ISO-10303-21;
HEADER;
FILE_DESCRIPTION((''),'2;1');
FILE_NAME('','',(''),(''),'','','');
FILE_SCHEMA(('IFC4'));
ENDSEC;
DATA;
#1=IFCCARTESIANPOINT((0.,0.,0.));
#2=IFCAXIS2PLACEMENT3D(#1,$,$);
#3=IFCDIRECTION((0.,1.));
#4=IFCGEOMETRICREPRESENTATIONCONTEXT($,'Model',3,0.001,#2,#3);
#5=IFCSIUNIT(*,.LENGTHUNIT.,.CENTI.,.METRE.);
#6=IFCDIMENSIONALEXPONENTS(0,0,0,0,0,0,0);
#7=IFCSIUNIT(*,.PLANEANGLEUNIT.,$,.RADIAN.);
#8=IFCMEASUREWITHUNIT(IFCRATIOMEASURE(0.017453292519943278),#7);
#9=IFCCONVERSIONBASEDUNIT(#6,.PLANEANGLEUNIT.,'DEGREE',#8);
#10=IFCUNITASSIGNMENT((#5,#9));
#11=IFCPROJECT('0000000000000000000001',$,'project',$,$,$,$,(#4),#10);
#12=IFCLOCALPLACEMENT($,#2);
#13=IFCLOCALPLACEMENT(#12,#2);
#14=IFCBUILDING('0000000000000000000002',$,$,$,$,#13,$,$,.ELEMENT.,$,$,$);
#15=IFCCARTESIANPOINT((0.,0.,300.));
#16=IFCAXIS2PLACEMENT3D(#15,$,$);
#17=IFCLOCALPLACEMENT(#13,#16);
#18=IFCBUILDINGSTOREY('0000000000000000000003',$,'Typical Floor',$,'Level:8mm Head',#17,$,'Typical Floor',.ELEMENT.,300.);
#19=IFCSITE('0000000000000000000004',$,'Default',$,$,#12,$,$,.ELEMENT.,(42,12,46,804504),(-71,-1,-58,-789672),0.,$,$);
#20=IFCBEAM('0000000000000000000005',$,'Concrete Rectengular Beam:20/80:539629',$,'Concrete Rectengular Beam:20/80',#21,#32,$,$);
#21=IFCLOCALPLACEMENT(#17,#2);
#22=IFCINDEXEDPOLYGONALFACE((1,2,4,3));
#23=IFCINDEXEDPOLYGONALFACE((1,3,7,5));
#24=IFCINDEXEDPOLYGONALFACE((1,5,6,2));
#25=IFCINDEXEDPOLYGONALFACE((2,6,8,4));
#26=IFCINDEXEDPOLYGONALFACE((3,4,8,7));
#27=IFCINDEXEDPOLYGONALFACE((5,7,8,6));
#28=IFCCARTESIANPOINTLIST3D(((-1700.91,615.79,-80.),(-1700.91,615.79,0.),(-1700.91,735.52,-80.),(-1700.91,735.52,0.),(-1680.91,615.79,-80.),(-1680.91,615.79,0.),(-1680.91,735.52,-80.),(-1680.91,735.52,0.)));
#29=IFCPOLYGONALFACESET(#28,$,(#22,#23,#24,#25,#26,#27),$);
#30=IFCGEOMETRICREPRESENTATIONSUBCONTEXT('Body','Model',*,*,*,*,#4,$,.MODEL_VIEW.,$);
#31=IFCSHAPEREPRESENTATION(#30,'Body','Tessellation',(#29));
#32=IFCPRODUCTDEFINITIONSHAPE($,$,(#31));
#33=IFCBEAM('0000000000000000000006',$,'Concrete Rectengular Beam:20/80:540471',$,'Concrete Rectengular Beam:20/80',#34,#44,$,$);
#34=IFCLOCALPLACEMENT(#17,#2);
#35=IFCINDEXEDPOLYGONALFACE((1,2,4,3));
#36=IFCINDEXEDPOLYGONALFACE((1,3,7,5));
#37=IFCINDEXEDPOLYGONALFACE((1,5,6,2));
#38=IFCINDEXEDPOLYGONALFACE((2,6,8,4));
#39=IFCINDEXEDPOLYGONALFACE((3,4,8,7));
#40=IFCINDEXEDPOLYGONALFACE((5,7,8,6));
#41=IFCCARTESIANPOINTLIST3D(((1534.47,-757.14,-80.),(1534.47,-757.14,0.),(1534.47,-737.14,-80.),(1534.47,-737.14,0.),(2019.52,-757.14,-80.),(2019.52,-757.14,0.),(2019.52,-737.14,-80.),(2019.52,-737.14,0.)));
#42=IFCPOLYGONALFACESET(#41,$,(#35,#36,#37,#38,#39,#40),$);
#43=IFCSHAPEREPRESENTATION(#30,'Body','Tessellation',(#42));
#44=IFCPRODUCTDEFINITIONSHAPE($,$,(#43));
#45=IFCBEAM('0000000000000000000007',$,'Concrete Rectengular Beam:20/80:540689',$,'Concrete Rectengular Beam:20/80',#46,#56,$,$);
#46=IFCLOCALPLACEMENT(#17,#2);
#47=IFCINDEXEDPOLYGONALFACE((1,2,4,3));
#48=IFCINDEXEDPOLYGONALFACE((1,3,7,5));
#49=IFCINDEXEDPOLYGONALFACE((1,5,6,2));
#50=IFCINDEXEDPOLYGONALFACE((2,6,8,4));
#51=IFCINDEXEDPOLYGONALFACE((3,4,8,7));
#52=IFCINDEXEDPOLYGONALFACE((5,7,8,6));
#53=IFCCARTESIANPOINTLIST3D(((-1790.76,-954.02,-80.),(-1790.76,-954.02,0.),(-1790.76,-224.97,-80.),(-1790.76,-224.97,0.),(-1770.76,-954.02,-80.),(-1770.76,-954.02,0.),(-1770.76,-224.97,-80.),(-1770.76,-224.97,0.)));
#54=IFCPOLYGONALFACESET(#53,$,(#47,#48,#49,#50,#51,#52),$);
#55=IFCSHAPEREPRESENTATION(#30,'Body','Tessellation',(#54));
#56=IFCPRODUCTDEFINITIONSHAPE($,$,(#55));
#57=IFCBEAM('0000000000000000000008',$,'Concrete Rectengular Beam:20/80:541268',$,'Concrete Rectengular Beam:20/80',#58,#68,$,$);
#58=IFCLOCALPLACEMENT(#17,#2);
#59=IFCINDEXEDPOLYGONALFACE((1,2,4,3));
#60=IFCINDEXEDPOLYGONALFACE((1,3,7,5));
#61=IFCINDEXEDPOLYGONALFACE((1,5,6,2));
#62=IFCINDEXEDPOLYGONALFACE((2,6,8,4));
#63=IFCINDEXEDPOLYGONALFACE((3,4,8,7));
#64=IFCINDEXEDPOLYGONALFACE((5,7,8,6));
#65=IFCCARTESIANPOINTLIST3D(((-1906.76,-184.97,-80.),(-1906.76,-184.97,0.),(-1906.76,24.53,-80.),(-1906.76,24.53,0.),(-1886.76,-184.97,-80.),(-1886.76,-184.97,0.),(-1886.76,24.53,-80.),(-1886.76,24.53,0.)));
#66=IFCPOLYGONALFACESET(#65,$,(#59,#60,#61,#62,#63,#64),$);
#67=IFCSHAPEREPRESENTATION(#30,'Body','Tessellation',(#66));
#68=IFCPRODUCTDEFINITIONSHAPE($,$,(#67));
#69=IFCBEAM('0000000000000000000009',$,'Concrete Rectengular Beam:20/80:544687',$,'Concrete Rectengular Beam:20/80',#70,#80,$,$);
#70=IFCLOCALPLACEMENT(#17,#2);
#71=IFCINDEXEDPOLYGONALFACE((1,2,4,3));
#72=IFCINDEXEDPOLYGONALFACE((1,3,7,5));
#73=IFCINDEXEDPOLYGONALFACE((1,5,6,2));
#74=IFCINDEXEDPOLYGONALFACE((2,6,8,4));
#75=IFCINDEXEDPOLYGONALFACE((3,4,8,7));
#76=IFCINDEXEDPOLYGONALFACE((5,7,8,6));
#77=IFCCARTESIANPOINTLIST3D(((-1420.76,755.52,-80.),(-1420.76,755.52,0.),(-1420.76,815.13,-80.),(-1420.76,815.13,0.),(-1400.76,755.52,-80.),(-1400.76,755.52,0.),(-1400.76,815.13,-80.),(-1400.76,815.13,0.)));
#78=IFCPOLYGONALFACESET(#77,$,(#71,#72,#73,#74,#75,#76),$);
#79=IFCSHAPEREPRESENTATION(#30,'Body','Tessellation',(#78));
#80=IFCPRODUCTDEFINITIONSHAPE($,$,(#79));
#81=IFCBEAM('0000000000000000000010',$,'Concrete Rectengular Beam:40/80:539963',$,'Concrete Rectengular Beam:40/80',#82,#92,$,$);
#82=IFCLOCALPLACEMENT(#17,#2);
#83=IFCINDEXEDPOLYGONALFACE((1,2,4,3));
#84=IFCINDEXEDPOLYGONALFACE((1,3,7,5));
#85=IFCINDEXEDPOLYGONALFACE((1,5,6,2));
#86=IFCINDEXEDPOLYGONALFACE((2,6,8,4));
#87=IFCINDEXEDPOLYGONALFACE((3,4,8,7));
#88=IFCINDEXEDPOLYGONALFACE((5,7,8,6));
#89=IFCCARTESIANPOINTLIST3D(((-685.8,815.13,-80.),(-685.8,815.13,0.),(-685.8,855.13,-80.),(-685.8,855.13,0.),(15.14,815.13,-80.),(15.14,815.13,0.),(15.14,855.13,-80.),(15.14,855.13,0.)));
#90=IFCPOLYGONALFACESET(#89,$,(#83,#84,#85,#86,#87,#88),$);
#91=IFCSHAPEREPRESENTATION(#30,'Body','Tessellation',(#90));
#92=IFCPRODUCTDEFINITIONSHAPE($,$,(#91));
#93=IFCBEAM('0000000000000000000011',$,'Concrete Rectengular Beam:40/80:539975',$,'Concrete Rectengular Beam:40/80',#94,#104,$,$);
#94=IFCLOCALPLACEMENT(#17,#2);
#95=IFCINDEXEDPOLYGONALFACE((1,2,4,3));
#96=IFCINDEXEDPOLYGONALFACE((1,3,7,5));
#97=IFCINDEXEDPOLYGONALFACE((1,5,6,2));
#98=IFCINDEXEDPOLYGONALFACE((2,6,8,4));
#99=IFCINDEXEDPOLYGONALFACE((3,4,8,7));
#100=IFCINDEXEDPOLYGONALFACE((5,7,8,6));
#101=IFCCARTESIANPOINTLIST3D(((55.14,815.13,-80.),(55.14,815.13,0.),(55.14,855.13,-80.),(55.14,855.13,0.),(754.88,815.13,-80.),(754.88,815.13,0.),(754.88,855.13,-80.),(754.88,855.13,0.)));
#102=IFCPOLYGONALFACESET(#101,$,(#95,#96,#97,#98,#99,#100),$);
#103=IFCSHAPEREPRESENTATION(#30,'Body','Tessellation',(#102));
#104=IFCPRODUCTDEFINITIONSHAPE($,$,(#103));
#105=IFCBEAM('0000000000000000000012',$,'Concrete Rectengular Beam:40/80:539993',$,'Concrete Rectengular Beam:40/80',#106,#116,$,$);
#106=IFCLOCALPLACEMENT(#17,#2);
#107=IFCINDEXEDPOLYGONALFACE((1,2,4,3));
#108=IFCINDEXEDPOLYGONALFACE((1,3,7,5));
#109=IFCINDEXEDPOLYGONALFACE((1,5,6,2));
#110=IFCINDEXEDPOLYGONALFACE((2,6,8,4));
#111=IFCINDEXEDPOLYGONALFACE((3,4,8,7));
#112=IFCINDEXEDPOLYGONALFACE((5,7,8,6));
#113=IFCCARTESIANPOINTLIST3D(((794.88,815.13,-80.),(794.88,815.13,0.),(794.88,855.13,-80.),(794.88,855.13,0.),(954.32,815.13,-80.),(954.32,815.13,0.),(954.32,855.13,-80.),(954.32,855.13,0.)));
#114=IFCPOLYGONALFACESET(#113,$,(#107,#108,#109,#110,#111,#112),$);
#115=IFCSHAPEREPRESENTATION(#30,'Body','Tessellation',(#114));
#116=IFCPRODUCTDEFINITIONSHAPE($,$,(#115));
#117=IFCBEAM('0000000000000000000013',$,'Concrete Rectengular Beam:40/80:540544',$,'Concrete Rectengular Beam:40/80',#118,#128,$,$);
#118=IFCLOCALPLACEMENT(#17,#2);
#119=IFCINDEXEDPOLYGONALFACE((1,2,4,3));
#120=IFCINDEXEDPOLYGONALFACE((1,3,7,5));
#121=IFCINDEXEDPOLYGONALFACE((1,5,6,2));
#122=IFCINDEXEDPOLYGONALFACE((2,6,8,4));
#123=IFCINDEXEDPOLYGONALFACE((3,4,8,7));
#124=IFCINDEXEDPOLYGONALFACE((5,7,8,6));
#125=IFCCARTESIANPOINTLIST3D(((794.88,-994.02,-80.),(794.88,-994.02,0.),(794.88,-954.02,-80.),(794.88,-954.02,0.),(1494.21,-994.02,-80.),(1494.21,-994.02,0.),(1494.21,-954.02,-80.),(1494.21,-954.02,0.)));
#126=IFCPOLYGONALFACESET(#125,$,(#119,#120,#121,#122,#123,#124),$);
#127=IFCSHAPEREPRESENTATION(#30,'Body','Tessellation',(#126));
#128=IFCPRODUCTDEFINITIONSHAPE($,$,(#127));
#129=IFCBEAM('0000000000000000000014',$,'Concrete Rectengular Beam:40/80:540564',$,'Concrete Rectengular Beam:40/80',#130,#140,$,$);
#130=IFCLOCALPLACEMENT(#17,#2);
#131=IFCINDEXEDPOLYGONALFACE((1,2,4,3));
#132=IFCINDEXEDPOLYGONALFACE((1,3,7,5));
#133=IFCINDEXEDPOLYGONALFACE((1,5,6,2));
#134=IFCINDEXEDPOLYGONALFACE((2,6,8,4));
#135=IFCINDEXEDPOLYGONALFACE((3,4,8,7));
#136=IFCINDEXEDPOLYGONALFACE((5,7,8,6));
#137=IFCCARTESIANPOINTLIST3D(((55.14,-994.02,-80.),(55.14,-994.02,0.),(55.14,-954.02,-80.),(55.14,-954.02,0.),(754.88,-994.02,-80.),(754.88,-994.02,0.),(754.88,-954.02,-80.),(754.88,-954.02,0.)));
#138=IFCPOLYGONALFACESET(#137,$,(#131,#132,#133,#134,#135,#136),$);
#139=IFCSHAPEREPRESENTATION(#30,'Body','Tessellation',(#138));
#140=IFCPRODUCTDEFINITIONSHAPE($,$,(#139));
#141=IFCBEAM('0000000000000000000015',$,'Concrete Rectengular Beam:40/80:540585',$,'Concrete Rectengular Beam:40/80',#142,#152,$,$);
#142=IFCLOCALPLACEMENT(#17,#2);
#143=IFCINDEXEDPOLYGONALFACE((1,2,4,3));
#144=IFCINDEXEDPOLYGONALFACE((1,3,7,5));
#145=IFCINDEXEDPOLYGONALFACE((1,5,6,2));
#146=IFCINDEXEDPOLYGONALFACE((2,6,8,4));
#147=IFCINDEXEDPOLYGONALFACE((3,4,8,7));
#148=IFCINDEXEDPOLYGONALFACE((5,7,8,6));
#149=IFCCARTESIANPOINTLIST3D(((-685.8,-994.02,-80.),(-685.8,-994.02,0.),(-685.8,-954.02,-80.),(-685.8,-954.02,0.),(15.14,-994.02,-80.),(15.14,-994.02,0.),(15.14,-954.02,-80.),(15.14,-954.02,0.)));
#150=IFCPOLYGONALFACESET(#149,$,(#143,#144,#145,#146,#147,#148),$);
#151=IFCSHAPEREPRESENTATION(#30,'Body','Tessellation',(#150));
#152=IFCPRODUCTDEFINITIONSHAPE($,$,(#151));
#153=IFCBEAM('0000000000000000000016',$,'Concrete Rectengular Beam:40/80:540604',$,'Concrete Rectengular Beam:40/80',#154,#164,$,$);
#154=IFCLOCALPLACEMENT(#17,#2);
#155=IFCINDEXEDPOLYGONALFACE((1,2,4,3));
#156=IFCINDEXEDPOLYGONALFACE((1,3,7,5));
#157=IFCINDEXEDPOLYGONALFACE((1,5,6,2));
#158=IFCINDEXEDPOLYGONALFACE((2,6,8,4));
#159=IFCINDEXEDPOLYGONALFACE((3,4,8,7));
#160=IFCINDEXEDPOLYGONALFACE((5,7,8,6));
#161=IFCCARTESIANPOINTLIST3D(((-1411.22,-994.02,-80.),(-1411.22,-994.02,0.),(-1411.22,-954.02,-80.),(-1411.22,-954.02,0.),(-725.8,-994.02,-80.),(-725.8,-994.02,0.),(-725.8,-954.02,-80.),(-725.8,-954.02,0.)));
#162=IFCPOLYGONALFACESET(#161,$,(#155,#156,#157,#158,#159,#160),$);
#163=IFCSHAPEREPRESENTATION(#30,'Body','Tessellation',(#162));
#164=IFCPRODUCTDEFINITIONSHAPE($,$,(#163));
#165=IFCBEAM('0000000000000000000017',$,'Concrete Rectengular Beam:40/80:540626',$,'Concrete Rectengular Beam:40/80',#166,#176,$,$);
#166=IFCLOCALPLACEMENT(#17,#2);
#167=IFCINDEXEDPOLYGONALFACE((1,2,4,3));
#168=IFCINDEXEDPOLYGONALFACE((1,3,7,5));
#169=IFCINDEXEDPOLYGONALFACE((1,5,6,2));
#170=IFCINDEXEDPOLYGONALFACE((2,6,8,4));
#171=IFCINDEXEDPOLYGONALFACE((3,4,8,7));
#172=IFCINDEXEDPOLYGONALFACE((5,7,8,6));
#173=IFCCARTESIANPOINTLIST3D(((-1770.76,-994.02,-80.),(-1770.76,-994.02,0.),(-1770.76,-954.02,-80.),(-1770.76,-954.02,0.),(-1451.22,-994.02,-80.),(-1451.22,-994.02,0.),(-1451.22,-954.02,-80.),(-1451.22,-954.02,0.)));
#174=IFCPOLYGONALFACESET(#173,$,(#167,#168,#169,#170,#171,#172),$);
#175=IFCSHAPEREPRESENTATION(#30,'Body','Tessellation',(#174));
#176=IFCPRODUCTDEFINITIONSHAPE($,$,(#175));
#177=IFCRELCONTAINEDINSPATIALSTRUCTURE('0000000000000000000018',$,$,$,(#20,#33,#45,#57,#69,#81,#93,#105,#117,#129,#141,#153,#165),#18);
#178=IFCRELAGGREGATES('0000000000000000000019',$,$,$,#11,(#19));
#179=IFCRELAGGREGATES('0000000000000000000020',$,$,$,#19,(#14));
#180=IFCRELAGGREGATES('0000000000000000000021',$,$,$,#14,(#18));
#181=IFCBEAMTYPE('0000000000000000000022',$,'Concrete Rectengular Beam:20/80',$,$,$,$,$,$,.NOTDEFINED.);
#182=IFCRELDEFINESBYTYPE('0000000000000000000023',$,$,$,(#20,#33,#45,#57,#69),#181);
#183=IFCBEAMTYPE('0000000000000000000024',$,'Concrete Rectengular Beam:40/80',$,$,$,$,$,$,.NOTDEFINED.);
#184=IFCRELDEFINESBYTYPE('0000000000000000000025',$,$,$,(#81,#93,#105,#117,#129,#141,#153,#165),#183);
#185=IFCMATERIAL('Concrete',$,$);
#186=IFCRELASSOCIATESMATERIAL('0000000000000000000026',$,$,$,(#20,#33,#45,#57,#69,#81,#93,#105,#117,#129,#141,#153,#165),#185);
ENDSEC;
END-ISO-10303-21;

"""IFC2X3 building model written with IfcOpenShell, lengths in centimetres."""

from ifc_helpers import new_model, entity, si_unit, converted_unit, direction, frame, frame_2d, origin, place, context, subcontext, project, spatial, rectangle, extrude, material, type_object, element, save


model = new_model("IFC2X3")

# Units and contexts
model_context = context("Model", 3, precision=0.001, world=origin(), true_north=direction((0.0, 1.0)))
body_context = subcontext(model_context, "Body", "Model", "MODEL_VIEW")
ifc_project = project(units=[si_unit("LENGTHUNIT", "METRE", prefix="CENTI"), converted_unit("PLANEANGLEUNIT", "DEGREE", entity("IfcRatioMeasure", 0.017453292519943278), si_unit("PLANEANGLEUNIT", "RADIAN"), dimensions=[0, 0, 0, 0, 0, 0, 0])], contexts=[model_context])

# Site, building, storey
site_placement = place(None, origin())
site = spatial("IfcSite", under=ifc_project, at=site_placement, Name="Default", CompositionType="ELEMENT", RefLatitude=(42, 12, 46, 804504), RefLongitude=(-71, -1, -58, -789672), RefElevation=0.0)
building_placement = place(site_placement, origin())
building = spatial("IfcBuilding", under=site, at=building_placement, CompositionType="ELEMENT")
storey_placement = place(building_placement, frame((0.0, 0.0, 300.0)))
storey = spatial("IfcBuildingStorey", under=building, at=storey_placement, Name="Typical Floor", ObjectType="Level:8mm Head", LongName="Typical Floor", CompositionType="ELEMENT", Elevation=300.0)

# Beams
ifc_material = material(Name="Concrete")
beam_type_1 = type_object("IfcBeamType", Name="Concrete Rectengular Beam:20/80", PredefinedType="NOTDEFINED")
beam_1_placement = place(storey_placement, frame((-1690.91, 745.52, 0.0), z_axis=(0.0, 0.0, 1.0), x_axis=(0.0, -1.0, 0.0)))
element("IfcBeam", 1, at=beam_1_placement, inside=storey, type_object=beam_type_1, material=ifc_material, Name="Concrete Rectengular Beam:20/80:539629", ObjectType="Concrete Rectengular Beam:20/80", context=body_context, shape_type="SweptSolid", body=[
    extrude(rectangle(XDim=80.0, YDim=20.0, at=frame_2d((0.0, 0.0), x_axis=(1.0, 0.0))), frame((10.0, 0.0, -40.0), z_axis=(1.0, 0.0, 0.0), x_axis=(0.0, 0.0, -1.0)), (0.0, 0.0, 1.0), 119.74),
])
beam_2_placement = place(storey_placement, frame((2029.52, -747.14, 0.0), z_axis=(0.0, 0.0, 1.0), x_axis=(-1.0, 0.0, 0.0)))
element("IfcBeam", 2, at=beam_2_placement, inside=storey, type_object=beam_type_1, material=ifc_material, Name="Concrete Rectengular Beam:20/80:540471", ObjectType="Concrete Rectengular Beam:20/80", context=body_context, shape_type="SweptSolid", body=[
    extrude(rectangle(XDim=80.0, YDim=20.0, at=frame_2d((0.0, 0.0), x_axis=(1.0, 0.0))), frame((10.0, 0.0, -40.0), z_axis=(1.0, 0.0, 0.0), x_axis=(0.0, 0.0, -1.0)), (0.0, 0.0, 1.0), 485.05),
])
beam_3_placement = place(storey_placement, frame((-1780.76, -204.97, 0.0), z_axis=(0.0, 0.0, 1.0), x_axis=(0.0, -1.0, 0.0)))
element("IfcBeam", 3, at=beam_3_placement, inside=storey, type_object=beam_type_1, material=ifc_material, Name="Concrete Rectengular Beam:20/80:540689", ObjectType="Concrete Rectengular Beam:20/80", context=body_context, shape_type="SweptSolid", body=[
    extrude(rectangle(XDim=80.0, YDim=20.0, at=frame_2d((0.0, 0.0), x_axis=(1.0, 0.0))), frame((20.0, 0.0, -40.0), z_axis=(1.0, 0.0, 0.0), x_axis=(0.0, 0.0, -1.0)), (0.0, 0.0, 1.0), 729.05),
])
beam_4_placement = place(storey_placement, frame((-1896.76, -204.97, 0.0), z_axis=(0.0, 0.0, 1.0), x_axis=(0.0, 1.0, 0.0)))
element("IfcBeam", 4, at=beam_4_placement, inside=storey, type_object=beam_type_1, material=ifc_material, Name="Concrete Rectengular Beam:20/80:541268", ObjectType="Concrete Rectengular Beam:20/80", context=body_context, shape_type="SweptSolid", body=[
    extrude(rectangle(XDim=80.0, YDim=20.0, at=frame_2d((0.0, 0.0), x_axis=(1.0, 0.0))), frame((20.0, 0.0, -40.0), z_axis=(1.0, 0.0, 0.0), x_axis=(0.0, 0.0, -1.0)), (0.0, 0.0, 1.0), 209.5),
])
beam_5_placement = place(storey_placement, frame((-1410.76, 835.13, 0.0), z_axis=(0.0, 0.0, 1.0), x_axis=(0.0, -1.0, 0.0)))
element("IfcBeam", 5, at=beam_5_placement, inside=storey, type_object=beam_type_1, material=ifc_material, Name="Concrete Rectengular Beam:20/80:544687", ObjectType="Concrete Rectengular Beam:20/80", context=body_context, shape_type="SweptSolid", body=[
    extrude(rectangle(XDim=80.0, YDim=20.0, at=frame_2d((0.0, 0.0), x_axis=(1.0, 0.0))), frame((20.0, 0.0, -40.0), z_axis=(1.0, 0.0, 0.0), x_axis=(0.0, 0.0, -1.0)), (0.0, 0.0, 1.0), 59.61),
])
beam_type_2 = type_object("IfcBeamType", Name="Concrete Rectengular Beam:40/80", PredefinedType="NOTDEFINED")
beam_6_placement = place(storey_placement, frame((-705.8, 835.13, 0.0)))
element("IfcBeam", 6, at=beam_6_placement, inside=storey, type_object=beam_type_2, material=ifc_material, Name="Concrete Rectengular Beam:40/80:539963", ObjectType="Concrete Rectengular Beam:40/80", context=body_context, shape_type="SweptSolid", body=[
    extrude(rectangle(XDim=80.0, YDim=40.0, at=frame_2d((0.0, 0.0), x_axis=(1.0, 0.0))), frame((20.0, 0.0, -40.0), z_axis=(1.0, 0.0, 0.0), x_axis=(0.0, 0.0, -1.0)), (0.0, 0.0, 1.0), 700.94),
])
beam_7_placement = place(storey_placement, frame((35.14, 835.13, 0.0)))
element("IfcBeam", 7, at=beam_7_placement, inside=storey, type_object=beam_type_2, material=ifc_material, Name="Concrete Rectengular Beam:40/80:539975", ObjectType="Concrete Rectengular Beam:40/80", context=body_context, shape_type="SweptSolid", body=[
    extrude(rectangle(XDim=80.0, YDim=40.0, at=frame_2d((0.0, 0.0), x_axis=(1.0, 0.0))), frame((20.0, 0.0, -40.0), z_axis=(1.0, 0.0, 0.0), x_axis=(0.0, 0.0, -1.0)), (0.0, 0.0, 1.0), 699.74),
])
beam_8_placement = place(storey_placement, frame((774.88, 835.13, 0.0)))
element("IfcBeam", 8, at=beam_8_placement, inside=storey, type_object=beam_type_2, material=ifc_material, Name="Concrete Rectengular Beam:40/80:539993", ObjectType="Concrete Rectengular Beam:40/80", context=body_context, shape_type="SweptSolid", body=[
    extrude(rectangle(XDim=80.0, YDim=40.0, at=frame_2d((0.0, 0.0), x_axis=(1.0, 0.0))), frame((20.0, 0.0, -40.0), z_axis=(1.0, 0.0, 0.0), x_axis=(0.0, 0.0, -1.0)), (0.0, 0.0, 1.0), 159.44),
])
beam_9_placement = place(storey_placement, frame((1514.21, -974.02, 0.0), z_axis=(0.0, 0.0, 1.0), x_axis=(-1.0, 0.0, 0.0)))
element("IfcBeam", 9, at=beam_9_placement, inside=storey, type_object=beam_type_2, material=ifc_material, Name="Concrete Rectengular Beam:40/80:540544", ObjectType="Concrete Rectengular Beam:40/80", context=body_context, shape_type="SweptSolid", body=[
    extrude(rectangle(XDim=80.0, YDim=40.0, at=frame_2d((0.0, 0.0), x_axis=(1.0, 0.0))), frame((20.0, 0.0, -40.0), z_axis=(1.0, 0.0, 0.0), x_axis=(0.0, 0.0, -1.0)), (0.0, 0.0, 1.0), 699.33),
])
beam_10_placement = place(storey_placement, frame((774.88, -974.02, 0.0), z_axis=(0.0, 0.0, 1.0), x_axis=(-1.0, 0.0, 0.0)))
element("IfcBeam", 10, at=beam_10_placement, inside=storey, type_object=beam_type_2, material=ifc_material, Name="Concrete Rectengular Beam:40/80:540564", ObjectType="Concrete Rectengular Beam:40/80", context=body_context, shape_type="SweptSolid", body=[
    extrude(rectangle(XDim=80.0, YDim=40.0, at=frame_2d((0.0, 0.0), x_axis=(1.0, 0.0))), frame((20.0, 0.0, -40.0), z_axis=(1.0, 0.0, 0.0), x_axis=(0.0, 0.0, -1.0)), (0.0, 0.0, 1.0), 699.74),
])
beam_11_placement = place(storey_placement, frame((35.14, -974.02, 0.0), z_axis=(0.0, 0.0, 1.0), x_axis=(-1.0, 0.0, 0.0)))
element("IfcBeam", 11, at=beam_11_placement, inside=storey, type_object=beam_type_2, material=ifc_material, Name="Concrete Rectengular Beam:40/80:540585", ObjectType="Concrete Rectengular Beam:40/80", context=body_context, shape_type="SweptSolid", body=[
    extrude(rectangle(XDim=80.0, YDim=40.0, at=frame_2d((0.0, 0.0), x_axis=(1.0, 0.0))), frame((20.0, 0.0, -40.0), z_axis=(1.0, 0.0, 0.0), x_axis=(0.0, 0.0, -1.0)), (0.0, 0.0, 1.0), 700.94),
])
beam_12_placement = place(storey_placement, frame((-705.8, -974.02, 0.0), z_axis=(0.0, 0.0, 1.0), x_axis=(-1.0, 0.0, 0.0)))
element("IfcBeam", 12, at=beam_12_placement, inside=storey, type_object=beam_type_2, material=ifc_material, Name="Concrete Rectengular Beam:40/80:540604", ObjectType="Concrete Rectengular Beam:40/80", context=body_context, shape_type="SweptSolid", body=[
    extrude(rectangle(XDim=80.0, YDim=40.0, at=frame_2d((0.0, 0.0), x_axis=(1.0, 0.0))), frame((20.0, 0.0, -40.0), z_axis=(1.0, 0.0, 0.0), x_axis=(0.0, 0.0, -1.0)), (0.0, 0.0, 1.0), 685.43),
])
beam_13_placement = place(storey_placement, frame((-1431.22, -974.02, 0.0), z_axis=(0.0, 0.0, 1.0), x_axis=(-1.0, 0.0, 0.0)))
element("IfcBeam", 13, at=beam_13_placement, inside=storey, type_object=beam_type_2, material=ifc_material, Name="Concrete Rectengular Beam:40/80:540626", ObjectType="Concrete Rectengular Beam:40/80", context=body_context, shape_type="SweptSolid", body=[
    extrude(rectangle(XDim=80.0, YDim=40.0, at=frame_2d((0.0, 0.0), x_axis=(1.0, 0.0))), frame((20.0, 0.0, -40.0), z_axis=(1.0, 0.0, 0.0), x_axis=(0.0, 0.0, -1.0)), (0.0, 0.0, 1.0), 319.54),
])

save(model, "model.ifc")
